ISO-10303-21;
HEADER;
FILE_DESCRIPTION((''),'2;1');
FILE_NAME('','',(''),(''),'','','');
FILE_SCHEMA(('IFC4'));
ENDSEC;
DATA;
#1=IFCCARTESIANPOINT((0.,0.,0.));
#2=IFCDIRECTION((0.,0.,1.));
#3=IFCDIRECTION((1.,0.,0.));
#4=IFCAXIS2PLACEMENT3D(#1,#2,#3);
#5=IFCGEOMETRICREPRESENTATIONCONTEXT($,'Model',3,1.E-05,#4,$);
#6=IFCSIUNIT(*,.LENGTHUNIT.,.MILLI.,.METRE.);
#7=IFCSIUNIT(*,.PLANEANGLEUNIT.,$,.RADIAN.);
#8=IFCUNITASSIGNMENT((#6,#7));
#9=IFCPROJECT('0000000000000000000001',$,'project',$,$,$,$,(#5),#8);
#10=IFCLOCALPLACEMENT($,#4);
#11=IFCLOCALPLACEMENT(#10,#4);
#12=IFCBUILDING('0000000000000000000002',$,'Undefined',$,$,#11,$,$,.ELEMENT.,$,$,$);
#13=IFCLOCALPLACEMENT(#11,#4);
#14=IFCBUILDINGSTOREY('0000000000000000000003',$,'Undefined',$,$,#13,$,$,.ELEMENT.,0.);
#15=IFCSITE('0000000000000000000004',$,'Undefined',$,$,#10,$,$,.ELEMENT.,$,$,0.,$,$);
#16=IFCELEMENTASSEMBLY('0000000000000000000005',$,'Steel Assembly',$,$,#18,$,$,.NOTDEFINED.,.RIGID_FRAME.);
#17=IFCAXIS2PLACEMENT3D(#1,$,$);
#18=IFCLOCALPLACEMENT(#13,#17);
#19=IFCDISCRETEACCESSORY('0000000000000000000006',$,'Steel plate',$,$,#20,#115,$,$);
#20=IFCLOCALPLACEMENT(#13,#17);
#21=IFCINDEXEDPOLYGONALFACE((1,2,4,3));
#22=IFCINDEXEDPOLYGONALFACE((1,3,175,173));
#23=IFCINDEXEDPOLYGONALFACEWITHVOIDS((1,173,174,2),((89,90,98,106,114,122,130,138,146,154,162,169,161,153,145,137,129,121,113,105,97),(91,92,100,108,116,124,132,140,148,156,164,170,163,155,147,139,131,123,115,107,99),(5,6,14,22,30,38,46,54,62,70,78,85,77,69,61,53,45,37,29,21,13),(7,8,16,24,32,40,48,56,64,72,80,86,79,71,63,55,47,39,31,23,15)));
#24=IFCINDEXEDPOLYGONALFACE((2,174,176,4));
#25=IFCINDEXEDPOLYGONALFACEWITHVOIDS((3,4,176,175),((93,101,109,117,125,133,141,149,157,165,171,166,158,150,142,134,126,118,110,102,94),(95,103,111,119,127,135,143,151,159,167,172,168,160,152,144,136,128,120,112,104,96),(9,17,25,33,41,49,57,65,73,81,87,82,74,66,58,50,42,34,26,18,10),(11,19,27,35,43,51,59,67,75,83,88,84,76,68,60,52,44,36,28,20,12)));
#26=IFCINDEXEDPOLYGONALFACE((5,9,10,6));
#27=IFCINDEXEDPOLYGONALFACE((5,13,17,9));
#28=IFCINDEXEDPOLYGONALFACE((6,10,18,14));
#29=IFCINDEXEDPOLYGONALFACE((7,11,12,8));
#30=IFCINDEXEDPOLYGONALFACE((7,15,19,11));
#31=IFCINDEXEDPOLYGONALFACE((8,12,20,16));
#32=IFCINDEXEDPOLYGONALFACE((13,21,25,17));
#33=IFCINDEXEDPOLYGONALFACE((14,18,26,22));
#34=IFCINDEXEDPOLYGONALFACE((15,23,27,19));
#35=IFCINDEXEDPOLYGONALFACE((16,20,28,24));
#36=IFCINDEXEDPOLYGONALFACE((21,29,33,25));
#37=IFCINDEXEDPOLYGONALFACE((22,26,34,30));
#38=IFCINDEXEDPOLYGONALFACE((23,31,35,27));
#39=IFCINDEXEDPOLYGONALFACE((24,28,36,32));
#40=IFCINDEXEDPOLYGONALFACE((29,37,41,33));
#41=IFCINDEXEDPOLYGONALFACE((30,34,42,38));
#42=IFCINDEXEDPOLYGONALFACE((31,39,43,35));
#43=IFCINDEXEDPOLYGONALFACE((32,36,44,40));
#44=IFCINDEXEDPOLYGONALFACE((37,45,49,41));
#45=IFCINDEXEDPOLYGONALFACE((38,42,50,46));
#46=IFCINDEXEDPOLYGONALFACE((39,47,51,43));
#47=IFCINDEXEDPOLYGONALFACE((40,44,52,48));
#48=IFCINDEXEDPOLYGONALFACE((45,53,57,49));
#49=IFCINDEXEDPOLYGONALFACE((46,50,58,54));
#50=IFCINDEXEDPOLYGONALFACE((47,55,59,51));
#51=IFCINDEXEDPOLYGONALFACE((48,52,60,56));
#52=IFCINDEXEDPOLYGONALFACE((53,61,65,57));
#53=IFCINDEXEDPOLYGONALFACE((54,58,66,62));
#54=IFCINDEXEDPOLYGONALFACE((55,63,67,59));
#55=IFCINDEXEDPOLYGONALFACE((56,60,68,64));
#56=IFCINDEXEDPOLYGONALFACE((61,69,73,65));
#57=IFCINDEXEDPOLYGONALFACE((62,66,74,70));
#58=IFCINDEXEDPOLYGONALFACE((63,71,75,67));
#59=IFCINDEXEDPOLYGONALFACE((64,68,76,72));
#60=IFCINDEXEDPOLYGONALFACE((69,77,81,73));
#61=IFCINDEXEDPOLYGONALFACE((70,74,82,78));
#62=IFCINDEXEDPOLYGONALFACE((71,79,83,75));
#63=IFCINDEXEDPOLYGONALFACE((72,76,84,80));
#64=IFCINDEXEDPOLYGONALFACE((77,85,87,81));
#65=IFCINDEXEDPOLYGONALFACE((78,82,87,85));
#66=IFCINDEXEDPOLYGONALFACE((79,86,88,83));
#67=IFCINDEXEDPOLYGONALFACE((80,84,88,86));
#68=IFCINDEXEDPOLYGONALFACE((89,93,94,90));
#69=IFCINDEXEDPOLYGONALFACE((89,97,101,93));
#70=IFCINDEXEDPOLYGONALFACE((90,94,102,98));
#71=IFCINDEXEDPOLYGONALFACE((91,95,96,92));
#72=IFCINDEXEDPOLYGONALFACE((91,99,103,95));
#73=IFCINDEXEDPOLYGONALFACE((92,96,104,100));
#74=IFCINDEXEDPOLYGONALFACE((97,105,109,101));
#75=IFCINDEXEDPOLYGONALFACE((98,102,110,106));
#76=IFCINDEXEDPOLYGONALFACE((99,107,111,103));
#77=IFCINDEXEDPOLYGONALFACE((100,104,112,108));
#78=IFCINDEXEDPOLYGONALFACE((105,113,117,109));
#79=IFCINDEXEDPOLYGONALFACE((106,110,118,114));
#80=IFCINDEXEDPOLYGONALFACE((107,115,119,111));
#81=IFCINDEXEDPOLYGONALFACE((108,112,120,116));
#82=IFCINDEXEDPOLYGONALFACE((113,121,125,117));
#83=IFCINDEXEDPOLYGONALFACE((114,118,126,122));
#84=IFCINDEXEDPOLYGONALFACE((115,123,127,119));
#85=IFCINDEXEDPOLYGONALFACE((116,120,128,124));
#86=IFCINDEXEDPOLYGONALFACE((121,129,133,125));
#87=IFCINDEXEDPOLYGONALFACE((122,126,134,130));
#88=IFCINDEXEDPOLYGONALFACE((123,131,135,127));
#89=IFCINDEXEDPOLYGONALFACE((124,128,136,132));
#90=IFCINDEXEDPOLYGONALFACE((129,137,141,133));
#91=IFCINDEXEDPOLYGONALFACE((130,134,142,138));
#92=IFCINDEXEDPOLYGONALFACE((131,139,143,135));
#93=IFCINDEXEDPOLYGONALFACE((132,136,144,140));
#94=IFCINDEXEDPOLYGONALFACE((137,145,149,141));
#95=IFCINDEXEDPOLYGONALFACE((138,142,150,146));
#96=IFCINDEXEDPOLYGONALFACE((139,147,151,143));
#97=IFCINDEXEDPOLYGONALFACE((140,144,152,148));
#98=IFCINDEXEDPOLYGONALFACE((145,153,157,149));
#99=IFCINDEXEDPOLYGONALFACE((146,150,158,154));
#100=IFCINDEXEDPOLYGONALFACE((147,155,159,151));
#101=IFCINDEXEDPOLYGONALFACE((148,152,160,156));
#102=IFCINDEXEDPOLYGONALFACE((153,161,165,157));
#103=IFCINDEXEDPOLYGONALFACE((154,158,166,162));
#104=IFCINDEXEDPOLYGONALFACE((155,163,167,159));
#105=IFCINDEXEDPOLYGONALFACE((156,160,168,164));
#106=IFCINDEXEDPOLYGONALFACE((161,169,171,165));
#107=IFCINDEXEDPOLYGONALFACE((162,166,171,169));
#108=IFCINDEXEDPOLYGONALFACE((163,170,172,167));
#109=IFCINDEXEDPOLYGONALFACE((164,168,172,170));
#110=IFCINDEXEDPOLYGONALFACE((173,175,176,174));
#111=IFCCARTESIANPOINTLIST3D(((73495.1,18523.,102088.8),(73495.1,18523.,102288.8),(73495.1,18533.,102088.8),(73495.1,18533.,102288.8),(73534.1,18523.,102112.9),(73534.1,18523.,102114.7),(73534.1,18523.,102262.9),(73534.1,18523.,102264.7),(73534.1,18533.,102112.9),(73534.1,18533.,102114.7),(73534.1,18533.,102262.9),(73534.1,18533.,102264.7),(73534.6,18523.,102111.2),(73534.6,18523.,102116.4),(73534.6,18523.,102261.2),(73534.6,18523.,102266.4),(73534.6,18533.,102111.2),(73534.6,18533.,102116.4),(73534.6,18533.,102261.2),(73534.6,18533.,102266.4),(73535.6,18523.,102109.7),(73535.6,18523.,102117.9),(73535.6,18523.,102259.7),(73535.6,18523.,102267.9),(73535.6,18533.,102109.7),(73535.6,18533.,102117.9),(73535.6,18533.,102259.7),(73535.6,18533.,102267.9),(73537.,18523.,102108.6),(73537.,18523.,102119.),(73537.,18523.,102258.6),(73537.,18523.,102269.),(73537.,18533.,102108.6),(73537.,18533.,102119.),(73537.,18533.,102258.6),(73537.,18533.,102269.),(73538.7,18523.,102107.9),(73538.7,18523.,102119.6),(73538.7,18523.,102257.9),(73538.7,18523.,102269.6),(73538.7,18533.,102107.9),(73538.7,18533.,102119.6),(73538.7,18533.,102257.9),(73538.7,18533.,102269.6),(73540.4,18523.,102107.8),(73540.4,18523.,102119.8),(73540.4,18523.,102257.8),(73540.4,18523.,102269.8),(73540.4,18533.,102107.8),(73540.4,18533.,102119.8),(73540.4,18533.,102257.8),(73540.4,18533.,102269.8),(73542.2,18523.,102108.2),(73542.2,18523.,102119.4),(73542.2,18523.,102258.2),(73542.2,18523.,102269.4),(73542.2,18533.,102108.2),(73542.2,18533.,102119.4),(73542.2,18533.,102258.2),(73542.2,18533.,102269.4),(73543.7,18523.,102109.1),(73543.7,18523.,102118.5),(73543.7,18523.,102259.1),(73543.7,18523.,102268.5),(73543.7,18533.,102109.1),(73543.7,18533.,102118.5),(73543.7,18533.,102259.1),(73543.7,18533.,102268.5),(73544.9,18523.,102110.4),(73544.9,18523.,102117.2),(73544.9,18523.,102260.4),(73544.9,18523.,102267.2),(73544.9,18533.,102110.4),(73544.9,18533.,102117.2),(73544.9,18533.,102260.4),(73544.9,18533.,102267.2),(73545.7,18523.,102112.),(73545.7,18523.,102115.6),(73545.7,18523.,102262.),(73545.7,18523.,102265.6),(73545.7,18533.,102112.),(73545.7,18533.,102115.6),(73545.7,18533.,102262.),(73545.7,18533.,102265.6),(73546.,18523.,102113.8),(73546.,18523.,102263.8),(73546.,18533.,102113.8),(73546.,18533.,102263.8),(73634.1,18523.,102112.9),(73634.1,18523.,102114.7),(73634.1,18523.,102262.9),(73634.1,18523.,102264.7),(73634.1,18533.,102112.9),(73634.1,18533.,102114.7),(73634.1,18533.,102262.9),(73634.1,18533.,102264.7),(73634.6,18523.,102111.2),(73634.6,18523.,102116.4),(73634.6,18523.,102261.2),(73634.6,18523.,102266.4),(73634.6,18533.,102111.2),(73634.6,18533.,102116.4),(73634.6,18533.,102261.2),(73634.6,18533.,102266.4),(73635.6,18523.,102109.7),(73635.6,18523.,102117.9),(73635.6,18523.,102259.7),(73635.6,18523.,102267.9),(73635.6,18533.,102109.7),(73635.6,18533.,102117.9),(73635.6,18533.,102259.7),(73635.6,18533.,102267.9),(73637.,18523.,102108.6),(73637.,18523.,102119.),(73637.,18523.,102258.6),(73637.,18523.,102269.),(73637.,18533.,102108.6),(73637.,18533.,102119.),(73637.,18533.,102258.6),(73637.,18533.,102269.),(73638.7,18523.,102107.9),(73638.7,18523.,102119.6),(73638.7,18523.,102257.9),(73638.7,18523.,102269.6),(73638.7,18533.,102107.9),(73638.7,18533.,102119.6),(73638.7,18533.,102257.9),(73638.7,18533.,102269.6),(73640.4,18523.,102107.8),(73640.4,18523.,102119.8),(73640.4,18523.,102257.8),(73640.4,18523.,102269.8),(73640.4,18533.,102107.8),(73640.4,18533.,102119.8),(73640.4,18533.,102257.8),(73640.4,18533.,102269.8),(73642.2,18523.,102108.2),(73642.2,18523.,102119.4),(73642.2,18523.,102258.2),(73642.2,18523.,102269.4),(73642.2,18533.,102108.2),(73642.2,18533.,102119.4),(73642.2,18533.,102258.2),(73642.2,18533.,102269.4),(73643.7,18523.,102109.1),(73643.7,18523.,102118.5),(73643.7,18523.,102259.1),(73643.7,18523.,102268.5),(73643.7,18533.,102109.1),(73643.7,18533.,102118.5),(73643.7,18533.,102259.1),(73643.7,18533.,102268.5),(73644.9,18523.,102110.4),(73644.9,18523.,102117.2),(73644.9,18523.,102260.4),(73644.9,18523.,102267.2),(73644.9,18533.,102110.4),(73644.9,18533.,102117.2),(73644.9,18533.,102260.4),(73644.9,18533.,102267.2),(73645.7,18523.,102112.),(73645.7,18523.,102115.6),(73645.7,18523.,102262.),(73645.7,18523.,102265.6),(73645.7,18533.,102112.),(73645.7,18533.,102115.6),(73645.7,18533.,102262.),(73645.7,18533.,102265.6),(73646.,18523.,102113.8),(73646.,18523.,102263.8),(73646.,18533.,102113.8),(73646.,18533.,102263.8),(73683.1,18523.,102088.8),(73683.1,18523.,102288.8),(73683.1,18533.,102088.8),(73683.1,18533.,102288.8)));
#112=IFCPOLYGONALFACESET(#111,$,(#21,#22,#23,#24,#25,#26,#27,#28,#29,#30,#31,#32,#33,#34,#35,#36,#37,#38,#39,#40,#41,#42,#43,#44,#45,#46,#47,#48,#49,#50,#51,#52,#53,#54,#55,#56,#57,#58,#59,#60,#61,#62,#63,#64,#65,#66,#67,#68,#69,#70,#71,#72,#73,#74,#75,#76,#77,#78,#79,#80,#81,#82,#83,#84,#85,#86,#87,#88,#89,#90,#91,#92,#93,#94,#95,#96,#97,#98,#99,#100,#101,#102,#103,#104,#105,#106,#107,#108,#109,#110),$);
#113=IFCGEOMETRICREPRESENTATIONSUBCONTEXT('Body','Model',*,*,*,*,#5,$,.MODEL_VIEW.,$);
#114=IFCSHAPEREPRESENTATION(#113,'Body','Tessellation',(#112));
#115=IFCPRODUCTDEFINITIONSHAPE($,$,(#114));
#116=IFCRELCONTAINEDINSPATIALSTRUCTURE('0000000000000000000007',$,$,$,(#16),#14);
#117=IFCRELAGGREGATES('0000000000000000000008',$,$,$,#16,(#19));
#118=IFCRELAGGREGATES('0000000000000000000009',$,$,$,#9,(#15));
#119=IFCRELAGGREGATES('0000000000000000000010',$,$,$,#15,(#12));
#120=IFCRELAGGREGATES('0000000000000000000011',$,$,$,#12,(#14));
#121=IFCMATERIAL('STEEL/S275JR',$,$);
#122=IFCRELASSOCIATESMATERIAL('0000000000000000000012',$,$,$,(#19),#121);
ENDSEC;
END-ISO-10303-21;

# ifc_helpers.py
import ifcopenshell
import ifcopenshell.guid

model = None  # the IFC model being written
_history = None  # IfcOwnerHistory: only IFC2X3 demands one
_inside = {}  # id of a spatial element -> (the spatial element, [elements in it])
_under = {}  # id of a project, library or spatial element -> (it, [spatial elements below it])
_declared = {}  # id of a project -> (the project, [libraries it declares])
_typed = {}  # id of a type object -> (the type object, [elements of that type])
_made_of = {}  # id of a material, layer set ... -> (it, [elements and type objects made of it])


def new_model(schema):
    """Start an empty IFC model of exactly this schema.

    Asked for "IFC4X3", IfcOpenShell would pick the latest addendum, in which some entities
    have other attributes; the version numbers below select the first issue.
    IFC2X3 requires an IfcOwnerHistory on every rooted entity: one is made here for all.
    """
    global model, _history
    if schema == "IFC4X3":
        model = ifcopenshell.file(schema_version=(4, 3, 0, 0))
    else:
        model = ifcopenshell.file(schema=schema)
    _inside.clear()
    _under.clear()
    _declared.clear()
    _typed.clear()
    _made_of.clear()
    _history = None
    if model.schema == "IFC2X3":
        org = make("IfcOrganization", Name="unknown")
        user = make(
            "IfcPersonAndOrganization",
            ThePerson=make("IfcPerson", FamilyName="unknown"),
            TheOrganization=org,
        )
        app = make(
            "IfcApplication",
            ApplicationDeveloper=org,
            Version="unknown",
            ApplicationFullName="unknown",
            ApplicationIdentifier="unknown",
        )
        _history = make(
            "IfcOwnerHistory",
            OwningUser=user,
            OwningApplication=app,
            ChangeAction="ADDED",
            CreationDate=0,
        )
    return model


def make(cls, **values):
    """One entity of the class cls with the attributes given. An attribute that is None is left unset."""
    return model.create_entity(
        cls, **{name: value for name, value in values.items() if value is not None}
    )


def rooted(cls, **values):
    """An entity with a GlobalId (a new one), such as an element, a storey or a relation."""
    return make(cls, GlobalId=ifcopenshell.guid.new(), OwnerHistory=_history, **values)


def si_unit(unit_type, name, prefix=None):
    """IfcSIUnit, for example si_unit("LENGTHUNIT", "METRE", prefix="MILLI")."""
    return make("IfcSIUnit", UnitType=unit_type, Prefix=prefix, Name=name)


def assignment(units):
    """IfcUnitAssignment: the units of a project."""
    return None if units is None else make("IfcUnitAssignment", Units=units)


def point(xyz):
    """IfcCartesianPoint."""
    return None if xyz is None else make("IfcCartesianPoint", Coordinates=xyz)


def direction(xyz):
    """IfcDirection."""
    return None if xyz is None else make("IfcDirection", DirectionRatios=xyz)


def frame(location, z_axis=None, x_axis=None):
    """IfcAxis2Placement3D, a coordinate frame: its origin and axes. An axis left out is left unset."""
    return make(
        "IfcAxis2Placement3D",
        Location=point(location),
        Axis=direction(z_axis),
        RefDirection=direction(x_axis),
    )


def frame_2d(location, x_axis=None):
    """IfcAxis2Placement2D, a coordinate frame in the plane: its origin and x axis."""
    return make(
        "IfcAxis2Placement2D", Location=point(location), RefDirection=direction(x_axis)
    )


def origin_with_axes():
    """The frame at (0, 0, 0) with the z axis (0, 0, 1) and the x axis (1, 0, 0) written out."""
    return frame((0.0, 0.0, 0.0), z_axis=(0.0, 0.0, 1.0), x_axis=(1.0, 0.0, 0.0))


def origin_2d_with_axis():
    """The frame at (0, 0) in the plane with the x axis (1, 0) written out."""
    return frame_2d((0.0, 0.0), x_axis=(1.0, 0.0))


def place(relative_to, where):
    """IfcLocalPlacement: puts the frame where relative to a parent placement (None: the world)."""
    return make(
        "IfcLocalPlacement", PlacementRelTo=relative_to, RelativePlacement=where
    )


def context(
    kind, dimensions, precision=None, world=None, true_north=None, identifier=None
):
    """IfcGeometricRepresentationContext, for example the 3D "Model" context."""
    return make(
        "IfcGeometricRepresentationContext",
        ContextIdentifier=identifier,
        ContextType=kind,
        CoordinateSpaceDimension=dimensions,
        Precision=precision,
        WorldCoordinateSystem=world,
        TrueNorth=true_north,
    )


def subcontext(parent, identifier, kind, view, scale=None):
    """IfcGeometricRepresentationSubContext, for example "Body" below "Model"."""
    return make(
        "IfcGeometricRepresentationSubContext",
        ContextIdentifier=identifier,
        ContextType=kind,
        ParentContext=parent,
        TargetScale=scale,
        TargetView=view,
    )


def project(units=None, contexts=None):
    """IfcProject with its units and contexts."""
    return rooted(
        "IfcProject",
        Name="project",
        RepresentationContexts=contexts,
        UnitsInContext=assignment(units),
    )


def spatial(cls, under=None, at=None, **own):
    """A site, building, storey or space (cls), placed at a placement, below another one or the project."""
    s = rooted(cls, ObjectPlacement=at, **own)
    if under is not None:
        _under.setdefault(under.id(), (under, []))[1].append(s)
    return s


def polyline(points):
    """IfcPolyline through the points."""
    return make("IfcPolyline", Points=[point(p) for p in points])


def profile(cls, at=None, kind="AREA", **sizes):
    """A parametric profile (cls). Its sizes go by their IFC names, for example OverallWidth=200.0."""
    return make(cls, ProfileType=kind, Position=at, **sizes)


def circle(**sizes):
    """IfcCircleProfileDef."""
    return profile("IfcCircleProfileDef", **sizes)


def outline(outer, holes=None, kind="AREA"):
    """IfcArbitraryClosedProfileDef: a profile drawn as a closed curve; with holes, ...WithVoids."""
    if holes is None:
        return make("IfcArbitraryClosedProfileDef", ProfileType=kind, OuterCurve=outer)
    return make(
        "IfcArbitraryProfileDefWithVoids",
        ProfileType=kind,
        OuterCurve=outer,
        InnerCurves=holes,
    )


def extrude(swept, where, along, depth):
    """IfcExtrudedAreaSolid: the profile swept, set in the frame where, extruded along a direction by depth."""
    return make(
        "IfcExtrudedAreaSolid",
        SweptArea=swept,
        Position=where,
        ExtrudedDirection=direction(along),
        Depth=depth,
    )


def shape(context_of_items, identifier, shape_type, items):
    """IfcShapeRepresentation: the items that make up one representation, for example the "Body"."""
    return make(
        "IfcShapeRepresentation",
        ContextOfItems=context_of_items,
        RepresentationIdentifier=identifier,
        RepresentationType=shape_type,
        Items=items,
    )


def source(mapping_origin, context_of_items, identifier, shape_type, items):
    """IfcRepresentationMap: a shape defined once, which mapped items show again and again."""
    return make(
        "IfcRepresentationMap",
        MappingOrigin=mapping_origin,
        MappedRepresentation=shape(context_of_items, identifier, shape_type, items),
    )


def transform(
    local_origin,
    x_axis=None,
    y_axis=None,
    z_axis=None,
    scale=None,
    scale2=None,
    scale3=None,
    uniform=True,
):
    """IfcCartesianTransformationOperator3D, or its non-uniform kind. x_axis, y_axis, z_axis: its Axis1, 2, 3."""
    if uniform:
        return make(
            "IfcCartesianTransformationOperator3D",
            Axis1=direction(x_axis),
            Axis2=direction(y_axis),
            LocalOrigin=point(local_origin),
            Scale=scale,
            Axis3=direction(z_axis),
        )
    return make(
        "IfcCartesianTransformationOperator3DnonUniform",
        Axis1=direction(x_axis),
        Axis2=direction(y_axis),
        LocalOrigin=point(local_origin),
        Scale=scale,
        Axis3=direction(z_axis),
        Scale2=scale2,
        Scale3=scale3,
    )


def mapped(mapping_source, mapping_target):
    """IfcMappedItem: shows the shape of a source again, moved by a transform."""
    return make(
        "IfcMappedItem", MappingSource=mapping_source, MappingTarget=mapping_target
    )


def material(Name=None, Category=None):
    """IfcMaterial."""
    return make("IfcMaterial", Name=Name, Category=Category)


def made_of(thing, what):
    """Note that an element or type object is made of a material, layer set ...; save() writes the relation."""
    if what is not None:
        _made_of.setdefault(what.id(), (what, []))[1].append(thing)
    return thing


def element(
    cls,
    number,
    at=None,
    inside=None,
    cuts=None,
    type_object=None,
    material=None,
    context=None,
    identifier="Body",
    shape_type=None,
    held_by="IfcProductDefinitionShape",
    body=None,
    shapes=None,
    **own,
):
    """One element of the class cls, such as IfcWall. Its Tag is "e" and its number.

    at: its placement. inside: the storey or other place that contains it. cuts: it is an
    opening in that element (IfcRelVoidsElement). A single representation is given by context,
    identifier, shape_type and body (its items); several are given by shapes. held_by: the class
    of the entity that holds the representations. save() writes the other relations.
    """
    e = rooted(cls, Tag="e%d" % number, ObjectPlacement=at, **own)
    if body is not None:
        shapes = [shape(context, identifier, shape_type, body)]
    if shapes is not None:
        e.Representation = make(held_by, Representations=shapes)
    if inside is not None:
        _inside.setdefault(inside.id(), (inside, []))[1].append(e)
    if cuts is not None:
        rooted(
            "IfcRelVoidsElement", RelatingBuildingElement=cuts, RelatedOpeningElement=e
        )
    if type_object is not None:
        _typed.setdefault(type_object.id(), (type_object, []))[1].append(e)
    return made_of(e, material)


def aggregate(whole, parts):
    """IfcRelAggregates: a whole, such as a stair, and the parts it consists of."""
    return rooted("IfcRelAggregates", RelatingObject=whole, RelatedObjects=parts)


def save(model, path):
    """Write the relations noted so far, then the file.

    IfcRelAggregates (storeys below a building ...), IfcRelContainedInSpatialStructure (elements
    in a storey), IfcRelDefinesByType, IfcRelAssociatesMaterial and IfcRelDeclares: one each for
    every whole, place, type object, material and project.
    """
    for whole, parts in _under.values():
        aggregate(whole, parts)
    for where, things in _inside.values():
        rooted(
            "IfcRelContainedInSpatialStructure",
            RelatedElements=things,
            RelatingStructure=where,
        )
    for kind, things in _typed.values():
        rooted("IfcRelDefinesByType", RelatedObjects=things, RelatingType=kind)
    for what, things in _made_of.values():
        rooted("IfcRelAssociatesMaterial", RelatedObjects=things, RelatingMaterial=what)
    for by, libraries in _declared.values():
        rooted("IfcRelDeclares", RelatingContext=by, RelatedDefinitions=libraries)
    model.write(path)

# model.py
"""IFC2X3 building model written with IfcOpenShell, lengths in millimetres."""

from ifc_helpers import new_model, si_unit, frame, origin_with_axes, origin_2d_with_axis, place, context, subcontext, project, spatial, polyline, circle, outline, extrude, source, transform, mapped, material, element, aggregate, save


model = new_model("IFC2X3")

# Units and contexts
model_context = context("Model", 3, precision=1e-05, world=origin_with_axes())
body_context = subcontext(model_context, "Body", "Model", "MODEL_VIEW")
ifc_project = project(units=[si_unit("LENGTHUNIT", "METRE", prefix="MILLI"), si_unit("PLANEANGLEUNIT", "RADIAN")], contexts=[model_context])

# Site, building, storey
site_placement = place(None, origin_with_axes())
site = spatial("IfcSite", under=ifc_project, at=site_placement, Name="Undefined", CompositionType="ELEMENT", RefElevation=0.0)
building_placement = place(site_placement, origin_with_axes())
building = spatial("IfcBuilding", under=site, at=building_placement, Name="Undefined", CompositionType="ELEMENT")
storey_placement = place(building_placement, origin_with_axes())
storey = spatial("IfcBuildingStorey", under=building, at=storey_placement, Name="Undefined", CompositionType="ELEMENT", Elevation=0.0)

# Element assembly
assembly_1_placement = place(storey_placement, origin_with_axes())
assembly_1 = element("IfcElementAssembly", 1, at=assembly_1_placement, inside=storey, Name="Steel Assembly", AssemblyPlace="NOTDEFINED", PredefinedType="RIGID_FRAME")

# Discrete accessory, opening
ifc_material_1 = material(Name="STEEL/S275JR")
shared_shape_1 = source(origin_with_axes(), body_context, "Body", "SweptSolid", [
    extrude(circle(Radius=6.0, at=origin_2d_with_axis()), frame((0.0, -0.2, 0.0), z_axis=(0.0, 1.0, 0.0), x_axis=(1.0, 0.0, 0.0)), (0.0, 0.0, 1.0), 10.2),
])
discrete_accessory_1_placement = place(assembly_1_placement, frame((73683.1, 18528.0, 102288.8), z_axis=(0.0, -1.0, 0.0), x_axis=(-1.0, 0.0, 0.0)))
discrete_accessory_1 = element("IfcDiscreteAccessory", 2, at=discrete_accessory_1_placement, material=ifc_material_1, Name="Steel plate", context=body_context, shape_type="SweptSolid", body=[
    extrude(outline(polyline([(0.0, 0.0), (188.0, 0.0), (188.0, 200.0), (0.0, 200.0), (0.0, 0.0)])), frame((0.0, 0.0, -5.0), z_axis=(0.0, 0.0, 1.0), x_axis=(1.0, 0.0, 0.0)), (0.0, 0.0, 1.0), 10.0),
])
opening_1_placement = place(assembly_1_placement, frame((73540.0, 18523.1, 102188.8), z_axis=(0.0, 0.0, 1.0), x_axis=(1.0, 0.0, 0.0)))
element("IfcOpeningElement", 3, at=opening_1_placement, cuts=discrete_accessory_1, ObjectType="Opening", context=body_context, shape_type="MappedRepresentation", body=[
    mapped(shared_shape_1, transform((0.0, 0.0, -75.0))),
    mapped(shared_shape_1, transform((100.0, 0.0, -75.0))),
    mapped(shared_shape_1, transform((0.0, 0.0, 75.0))),
    mapped(shared_shape_1, transform((100.0, 0.0, 75.0))),
])

aggregate(assembly_1, [discrete_accessory_1])

save(model, "model.ifc")
